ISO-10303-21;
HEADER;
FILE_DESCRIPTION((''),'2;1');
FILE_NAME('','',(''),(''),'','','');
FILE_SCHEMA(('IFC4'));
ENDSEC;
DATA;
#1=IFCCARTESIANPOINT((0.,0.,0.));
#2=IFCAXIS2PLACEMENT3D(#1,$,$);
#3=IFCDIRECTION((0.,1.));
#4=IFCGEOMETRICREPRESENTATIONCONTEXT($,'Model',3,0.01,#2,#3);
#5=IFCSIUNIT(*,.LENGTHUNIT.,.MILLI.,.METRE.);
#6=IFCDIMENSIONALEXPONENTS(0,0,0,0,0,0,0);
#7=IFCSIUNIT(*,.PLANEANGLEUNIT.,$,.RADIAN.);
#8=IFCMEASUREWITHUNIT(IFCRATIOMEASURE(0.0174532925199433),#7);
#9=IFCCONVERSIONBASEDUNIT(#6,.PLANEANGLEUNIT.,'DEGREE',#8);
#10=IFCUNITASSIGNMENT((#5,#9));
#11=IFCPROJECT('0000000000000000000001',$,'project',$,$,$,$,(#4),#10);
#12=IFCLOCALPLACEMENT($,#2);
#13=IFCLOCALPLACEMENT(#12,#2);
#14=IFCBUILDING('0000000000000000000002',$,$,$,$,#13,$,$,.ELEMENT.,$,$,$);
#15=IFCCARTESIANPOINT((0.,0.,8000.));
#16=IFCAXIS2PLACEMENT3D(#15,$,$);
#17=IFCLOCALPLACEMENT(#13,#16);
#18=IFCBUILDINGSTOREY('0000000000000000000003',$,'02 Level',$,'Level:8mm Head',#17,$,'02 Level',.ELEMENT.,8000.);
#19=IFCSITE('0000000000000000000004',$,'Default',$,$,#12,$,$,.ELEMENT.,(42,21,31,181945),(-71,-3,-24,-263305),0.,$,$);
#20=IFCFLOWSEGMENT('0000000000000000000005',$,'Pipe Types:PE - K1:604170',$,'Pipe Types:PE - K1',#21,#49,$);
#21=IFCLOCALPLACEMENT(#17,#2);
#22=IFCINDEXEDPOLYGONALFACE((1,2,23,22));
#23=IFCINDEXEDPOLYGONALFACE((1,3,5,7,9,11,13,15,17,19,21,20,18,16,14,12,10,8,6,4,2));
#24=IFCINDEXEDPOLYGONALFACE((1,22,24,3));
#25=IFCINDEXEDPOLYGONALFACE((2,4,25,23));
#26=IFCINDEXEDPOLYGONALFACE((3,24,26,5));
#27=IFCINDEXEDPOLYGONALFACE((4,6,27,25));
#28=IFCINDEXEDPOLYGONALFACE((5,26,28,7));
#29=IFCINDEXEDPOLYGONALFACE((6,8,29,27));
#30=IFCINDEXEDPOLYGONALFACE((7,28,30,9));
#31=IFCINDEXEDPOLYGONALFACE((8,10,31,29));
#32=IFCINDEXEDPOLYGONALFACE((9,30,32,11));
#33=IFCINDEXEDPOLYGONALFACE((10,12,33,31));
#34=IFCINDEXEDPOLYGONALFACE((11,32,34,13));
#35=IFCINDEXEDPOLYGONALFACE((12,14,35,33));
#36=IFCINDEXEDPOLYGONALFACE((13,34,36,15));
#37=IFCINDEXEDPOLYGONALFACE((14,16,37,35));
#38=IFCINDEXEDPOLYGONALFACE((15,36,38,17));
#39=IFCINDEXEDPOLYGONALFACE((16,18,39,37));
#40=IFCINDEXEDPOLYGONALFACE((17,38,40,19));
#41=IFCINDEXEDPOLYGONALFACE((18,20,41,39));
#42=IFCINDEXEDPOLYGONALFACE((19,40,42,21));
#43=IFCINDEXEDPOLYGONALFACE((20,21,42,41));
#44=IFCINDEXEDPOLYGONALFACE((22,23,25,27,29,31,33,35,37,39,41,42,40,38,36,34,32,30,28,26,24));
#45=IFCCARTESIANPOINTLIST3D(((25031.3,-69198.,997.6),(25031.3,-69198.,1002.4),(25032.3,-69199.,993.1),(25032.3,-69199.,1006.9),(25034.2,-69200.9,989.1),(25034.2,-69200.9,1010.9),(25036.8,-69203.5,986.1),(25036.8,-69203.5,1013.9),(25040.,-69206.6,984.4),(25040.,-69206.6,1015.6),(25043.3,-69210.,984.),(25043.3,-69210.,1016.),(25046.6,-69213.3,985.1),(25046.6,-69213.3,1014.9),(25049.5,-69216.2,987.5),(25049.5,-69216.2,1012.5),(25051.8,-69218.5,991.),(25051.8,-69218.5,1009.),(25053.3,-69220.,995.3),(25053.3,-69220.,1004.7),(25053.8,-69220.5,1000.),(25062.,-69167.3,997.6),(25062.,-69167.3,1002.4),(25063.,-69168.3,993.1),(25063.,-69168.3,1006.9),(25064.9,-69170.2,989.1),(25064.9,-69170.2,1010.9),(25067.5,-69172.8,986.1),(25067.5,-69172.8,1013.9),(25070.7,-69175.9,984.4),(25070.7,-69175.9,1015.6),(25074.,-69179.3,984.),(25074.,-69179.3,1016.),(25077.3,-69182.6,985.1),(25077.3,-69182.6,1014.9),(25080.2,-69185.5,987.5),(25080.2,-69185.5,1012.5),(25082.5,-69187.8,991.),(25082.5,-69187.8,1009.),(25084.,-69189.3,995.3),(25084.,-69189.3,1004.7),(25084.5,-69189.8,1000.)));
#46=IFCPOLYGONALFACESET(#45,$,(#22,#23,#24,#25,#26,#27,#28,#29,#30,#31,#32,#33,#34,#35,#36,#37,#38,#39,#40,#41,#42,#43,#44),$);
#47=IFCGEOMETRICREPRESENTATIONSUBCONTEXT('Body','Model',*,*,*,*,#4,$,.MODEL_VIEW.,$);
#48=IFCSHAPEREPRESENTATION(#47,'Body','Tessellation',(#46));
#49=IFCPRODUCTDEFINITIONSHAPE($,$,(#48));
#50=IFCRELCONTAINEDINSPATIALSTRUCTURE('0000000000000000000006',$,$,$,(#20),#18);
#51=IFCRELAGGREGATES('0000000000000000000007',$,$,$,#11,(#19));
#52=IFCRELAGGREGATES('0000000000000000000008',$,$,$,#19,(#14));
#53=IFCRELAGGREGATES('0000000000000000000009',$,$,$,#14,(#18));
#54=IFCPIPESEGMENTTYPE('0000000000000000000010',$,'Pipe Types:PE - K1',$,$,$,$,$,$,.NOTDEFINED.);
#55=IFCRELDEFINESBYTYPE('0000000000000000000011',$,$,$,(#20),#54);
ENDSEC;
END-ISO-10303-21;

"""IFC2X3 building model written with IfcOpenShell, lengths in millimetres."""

from ifc_helpers import new_model, entity, si_unit, converted_unit, direction, frame, frame_2d, origin, place, context, subcontext, project, spatial, circle, extrude, type_object, element, save


model = new_model("IFC2X3")

# Units and contexts
model_context = context("Model", 3, precision=0.01, world=origin(), true_north=direction((0.0, 1.0)))
body_context = subcontext(model_context, "Body", "Model", "MODEL_VIEW")
ifc_project = project(units=[si_unit("LENGTHUNIT", "METRE", prefix="MILLI"), converted_unit("PLANEANGLEUNIT", "DEGREE", entity("IfcRatioMeasure", 0.0174532925199433), si_unit("PLANEANGLEUNIT", "RADIAN"), dimensions=[0, 0, 0, 0, 0, 0, 0])], contexts=[model_context])

# Site, building, storey
site_placement = place(None, origin())
site = spatial("IfcSite", under=ifc_project, at=site_placement, Name="Default", CompositionType="ELEMENT", RefLatitude=(42, 21, 31, 181945), RefLongitude=(-71, -3, -24, -263305), RefElevation=0.0)
building_placement = place(site_placement, origin())
building = spatial("IfcBuilding", under=site, at=building_placement, CompositionType="ELEMENT")
storey_placement = place(building_placement, frame((0.0, 0.0, 8000.0)))
storey = spatial("IfcBuildingStorey", under=building, at=storey_placement, Name="02 Level", ObjectType="Level:8mm Head", LongName="02 Level", CompositionType="ELEMENT", Elevation=8000.0)

# Flow segment
pipe_segment_type = type_object("IfcPipeSegmentType", Name="Pipe Types:PE - K1", PredefinedType="NOTDEFINED")
flow_segment_1_placement = place(storey_placement, frame((25029.6, -69222.1, 982.4)))
element("IfcFlowSegment", 1, at=flow_segment_1_placement, inside=storey, type_object=pipe_segment_type, Name="Pipe Types:PE - K1:604170", ObjectType="Pipe Types:PE - K1", context=body_context, shape_type="SweptSolid", body=[
    extrude(circle(Radius=16.0, at=frame_2d((0.0, 0.0), x_axis=(1.0, 0.0))), frame((12.9, 12.9, 17.6), z_axis=(0.707107, 0.707107, 0.0), x_axis=(0.707107, -0.707107, 0.0)), (0.0, 0.0, 1.0), 43.4),
])

save(model, "model.ifc")
